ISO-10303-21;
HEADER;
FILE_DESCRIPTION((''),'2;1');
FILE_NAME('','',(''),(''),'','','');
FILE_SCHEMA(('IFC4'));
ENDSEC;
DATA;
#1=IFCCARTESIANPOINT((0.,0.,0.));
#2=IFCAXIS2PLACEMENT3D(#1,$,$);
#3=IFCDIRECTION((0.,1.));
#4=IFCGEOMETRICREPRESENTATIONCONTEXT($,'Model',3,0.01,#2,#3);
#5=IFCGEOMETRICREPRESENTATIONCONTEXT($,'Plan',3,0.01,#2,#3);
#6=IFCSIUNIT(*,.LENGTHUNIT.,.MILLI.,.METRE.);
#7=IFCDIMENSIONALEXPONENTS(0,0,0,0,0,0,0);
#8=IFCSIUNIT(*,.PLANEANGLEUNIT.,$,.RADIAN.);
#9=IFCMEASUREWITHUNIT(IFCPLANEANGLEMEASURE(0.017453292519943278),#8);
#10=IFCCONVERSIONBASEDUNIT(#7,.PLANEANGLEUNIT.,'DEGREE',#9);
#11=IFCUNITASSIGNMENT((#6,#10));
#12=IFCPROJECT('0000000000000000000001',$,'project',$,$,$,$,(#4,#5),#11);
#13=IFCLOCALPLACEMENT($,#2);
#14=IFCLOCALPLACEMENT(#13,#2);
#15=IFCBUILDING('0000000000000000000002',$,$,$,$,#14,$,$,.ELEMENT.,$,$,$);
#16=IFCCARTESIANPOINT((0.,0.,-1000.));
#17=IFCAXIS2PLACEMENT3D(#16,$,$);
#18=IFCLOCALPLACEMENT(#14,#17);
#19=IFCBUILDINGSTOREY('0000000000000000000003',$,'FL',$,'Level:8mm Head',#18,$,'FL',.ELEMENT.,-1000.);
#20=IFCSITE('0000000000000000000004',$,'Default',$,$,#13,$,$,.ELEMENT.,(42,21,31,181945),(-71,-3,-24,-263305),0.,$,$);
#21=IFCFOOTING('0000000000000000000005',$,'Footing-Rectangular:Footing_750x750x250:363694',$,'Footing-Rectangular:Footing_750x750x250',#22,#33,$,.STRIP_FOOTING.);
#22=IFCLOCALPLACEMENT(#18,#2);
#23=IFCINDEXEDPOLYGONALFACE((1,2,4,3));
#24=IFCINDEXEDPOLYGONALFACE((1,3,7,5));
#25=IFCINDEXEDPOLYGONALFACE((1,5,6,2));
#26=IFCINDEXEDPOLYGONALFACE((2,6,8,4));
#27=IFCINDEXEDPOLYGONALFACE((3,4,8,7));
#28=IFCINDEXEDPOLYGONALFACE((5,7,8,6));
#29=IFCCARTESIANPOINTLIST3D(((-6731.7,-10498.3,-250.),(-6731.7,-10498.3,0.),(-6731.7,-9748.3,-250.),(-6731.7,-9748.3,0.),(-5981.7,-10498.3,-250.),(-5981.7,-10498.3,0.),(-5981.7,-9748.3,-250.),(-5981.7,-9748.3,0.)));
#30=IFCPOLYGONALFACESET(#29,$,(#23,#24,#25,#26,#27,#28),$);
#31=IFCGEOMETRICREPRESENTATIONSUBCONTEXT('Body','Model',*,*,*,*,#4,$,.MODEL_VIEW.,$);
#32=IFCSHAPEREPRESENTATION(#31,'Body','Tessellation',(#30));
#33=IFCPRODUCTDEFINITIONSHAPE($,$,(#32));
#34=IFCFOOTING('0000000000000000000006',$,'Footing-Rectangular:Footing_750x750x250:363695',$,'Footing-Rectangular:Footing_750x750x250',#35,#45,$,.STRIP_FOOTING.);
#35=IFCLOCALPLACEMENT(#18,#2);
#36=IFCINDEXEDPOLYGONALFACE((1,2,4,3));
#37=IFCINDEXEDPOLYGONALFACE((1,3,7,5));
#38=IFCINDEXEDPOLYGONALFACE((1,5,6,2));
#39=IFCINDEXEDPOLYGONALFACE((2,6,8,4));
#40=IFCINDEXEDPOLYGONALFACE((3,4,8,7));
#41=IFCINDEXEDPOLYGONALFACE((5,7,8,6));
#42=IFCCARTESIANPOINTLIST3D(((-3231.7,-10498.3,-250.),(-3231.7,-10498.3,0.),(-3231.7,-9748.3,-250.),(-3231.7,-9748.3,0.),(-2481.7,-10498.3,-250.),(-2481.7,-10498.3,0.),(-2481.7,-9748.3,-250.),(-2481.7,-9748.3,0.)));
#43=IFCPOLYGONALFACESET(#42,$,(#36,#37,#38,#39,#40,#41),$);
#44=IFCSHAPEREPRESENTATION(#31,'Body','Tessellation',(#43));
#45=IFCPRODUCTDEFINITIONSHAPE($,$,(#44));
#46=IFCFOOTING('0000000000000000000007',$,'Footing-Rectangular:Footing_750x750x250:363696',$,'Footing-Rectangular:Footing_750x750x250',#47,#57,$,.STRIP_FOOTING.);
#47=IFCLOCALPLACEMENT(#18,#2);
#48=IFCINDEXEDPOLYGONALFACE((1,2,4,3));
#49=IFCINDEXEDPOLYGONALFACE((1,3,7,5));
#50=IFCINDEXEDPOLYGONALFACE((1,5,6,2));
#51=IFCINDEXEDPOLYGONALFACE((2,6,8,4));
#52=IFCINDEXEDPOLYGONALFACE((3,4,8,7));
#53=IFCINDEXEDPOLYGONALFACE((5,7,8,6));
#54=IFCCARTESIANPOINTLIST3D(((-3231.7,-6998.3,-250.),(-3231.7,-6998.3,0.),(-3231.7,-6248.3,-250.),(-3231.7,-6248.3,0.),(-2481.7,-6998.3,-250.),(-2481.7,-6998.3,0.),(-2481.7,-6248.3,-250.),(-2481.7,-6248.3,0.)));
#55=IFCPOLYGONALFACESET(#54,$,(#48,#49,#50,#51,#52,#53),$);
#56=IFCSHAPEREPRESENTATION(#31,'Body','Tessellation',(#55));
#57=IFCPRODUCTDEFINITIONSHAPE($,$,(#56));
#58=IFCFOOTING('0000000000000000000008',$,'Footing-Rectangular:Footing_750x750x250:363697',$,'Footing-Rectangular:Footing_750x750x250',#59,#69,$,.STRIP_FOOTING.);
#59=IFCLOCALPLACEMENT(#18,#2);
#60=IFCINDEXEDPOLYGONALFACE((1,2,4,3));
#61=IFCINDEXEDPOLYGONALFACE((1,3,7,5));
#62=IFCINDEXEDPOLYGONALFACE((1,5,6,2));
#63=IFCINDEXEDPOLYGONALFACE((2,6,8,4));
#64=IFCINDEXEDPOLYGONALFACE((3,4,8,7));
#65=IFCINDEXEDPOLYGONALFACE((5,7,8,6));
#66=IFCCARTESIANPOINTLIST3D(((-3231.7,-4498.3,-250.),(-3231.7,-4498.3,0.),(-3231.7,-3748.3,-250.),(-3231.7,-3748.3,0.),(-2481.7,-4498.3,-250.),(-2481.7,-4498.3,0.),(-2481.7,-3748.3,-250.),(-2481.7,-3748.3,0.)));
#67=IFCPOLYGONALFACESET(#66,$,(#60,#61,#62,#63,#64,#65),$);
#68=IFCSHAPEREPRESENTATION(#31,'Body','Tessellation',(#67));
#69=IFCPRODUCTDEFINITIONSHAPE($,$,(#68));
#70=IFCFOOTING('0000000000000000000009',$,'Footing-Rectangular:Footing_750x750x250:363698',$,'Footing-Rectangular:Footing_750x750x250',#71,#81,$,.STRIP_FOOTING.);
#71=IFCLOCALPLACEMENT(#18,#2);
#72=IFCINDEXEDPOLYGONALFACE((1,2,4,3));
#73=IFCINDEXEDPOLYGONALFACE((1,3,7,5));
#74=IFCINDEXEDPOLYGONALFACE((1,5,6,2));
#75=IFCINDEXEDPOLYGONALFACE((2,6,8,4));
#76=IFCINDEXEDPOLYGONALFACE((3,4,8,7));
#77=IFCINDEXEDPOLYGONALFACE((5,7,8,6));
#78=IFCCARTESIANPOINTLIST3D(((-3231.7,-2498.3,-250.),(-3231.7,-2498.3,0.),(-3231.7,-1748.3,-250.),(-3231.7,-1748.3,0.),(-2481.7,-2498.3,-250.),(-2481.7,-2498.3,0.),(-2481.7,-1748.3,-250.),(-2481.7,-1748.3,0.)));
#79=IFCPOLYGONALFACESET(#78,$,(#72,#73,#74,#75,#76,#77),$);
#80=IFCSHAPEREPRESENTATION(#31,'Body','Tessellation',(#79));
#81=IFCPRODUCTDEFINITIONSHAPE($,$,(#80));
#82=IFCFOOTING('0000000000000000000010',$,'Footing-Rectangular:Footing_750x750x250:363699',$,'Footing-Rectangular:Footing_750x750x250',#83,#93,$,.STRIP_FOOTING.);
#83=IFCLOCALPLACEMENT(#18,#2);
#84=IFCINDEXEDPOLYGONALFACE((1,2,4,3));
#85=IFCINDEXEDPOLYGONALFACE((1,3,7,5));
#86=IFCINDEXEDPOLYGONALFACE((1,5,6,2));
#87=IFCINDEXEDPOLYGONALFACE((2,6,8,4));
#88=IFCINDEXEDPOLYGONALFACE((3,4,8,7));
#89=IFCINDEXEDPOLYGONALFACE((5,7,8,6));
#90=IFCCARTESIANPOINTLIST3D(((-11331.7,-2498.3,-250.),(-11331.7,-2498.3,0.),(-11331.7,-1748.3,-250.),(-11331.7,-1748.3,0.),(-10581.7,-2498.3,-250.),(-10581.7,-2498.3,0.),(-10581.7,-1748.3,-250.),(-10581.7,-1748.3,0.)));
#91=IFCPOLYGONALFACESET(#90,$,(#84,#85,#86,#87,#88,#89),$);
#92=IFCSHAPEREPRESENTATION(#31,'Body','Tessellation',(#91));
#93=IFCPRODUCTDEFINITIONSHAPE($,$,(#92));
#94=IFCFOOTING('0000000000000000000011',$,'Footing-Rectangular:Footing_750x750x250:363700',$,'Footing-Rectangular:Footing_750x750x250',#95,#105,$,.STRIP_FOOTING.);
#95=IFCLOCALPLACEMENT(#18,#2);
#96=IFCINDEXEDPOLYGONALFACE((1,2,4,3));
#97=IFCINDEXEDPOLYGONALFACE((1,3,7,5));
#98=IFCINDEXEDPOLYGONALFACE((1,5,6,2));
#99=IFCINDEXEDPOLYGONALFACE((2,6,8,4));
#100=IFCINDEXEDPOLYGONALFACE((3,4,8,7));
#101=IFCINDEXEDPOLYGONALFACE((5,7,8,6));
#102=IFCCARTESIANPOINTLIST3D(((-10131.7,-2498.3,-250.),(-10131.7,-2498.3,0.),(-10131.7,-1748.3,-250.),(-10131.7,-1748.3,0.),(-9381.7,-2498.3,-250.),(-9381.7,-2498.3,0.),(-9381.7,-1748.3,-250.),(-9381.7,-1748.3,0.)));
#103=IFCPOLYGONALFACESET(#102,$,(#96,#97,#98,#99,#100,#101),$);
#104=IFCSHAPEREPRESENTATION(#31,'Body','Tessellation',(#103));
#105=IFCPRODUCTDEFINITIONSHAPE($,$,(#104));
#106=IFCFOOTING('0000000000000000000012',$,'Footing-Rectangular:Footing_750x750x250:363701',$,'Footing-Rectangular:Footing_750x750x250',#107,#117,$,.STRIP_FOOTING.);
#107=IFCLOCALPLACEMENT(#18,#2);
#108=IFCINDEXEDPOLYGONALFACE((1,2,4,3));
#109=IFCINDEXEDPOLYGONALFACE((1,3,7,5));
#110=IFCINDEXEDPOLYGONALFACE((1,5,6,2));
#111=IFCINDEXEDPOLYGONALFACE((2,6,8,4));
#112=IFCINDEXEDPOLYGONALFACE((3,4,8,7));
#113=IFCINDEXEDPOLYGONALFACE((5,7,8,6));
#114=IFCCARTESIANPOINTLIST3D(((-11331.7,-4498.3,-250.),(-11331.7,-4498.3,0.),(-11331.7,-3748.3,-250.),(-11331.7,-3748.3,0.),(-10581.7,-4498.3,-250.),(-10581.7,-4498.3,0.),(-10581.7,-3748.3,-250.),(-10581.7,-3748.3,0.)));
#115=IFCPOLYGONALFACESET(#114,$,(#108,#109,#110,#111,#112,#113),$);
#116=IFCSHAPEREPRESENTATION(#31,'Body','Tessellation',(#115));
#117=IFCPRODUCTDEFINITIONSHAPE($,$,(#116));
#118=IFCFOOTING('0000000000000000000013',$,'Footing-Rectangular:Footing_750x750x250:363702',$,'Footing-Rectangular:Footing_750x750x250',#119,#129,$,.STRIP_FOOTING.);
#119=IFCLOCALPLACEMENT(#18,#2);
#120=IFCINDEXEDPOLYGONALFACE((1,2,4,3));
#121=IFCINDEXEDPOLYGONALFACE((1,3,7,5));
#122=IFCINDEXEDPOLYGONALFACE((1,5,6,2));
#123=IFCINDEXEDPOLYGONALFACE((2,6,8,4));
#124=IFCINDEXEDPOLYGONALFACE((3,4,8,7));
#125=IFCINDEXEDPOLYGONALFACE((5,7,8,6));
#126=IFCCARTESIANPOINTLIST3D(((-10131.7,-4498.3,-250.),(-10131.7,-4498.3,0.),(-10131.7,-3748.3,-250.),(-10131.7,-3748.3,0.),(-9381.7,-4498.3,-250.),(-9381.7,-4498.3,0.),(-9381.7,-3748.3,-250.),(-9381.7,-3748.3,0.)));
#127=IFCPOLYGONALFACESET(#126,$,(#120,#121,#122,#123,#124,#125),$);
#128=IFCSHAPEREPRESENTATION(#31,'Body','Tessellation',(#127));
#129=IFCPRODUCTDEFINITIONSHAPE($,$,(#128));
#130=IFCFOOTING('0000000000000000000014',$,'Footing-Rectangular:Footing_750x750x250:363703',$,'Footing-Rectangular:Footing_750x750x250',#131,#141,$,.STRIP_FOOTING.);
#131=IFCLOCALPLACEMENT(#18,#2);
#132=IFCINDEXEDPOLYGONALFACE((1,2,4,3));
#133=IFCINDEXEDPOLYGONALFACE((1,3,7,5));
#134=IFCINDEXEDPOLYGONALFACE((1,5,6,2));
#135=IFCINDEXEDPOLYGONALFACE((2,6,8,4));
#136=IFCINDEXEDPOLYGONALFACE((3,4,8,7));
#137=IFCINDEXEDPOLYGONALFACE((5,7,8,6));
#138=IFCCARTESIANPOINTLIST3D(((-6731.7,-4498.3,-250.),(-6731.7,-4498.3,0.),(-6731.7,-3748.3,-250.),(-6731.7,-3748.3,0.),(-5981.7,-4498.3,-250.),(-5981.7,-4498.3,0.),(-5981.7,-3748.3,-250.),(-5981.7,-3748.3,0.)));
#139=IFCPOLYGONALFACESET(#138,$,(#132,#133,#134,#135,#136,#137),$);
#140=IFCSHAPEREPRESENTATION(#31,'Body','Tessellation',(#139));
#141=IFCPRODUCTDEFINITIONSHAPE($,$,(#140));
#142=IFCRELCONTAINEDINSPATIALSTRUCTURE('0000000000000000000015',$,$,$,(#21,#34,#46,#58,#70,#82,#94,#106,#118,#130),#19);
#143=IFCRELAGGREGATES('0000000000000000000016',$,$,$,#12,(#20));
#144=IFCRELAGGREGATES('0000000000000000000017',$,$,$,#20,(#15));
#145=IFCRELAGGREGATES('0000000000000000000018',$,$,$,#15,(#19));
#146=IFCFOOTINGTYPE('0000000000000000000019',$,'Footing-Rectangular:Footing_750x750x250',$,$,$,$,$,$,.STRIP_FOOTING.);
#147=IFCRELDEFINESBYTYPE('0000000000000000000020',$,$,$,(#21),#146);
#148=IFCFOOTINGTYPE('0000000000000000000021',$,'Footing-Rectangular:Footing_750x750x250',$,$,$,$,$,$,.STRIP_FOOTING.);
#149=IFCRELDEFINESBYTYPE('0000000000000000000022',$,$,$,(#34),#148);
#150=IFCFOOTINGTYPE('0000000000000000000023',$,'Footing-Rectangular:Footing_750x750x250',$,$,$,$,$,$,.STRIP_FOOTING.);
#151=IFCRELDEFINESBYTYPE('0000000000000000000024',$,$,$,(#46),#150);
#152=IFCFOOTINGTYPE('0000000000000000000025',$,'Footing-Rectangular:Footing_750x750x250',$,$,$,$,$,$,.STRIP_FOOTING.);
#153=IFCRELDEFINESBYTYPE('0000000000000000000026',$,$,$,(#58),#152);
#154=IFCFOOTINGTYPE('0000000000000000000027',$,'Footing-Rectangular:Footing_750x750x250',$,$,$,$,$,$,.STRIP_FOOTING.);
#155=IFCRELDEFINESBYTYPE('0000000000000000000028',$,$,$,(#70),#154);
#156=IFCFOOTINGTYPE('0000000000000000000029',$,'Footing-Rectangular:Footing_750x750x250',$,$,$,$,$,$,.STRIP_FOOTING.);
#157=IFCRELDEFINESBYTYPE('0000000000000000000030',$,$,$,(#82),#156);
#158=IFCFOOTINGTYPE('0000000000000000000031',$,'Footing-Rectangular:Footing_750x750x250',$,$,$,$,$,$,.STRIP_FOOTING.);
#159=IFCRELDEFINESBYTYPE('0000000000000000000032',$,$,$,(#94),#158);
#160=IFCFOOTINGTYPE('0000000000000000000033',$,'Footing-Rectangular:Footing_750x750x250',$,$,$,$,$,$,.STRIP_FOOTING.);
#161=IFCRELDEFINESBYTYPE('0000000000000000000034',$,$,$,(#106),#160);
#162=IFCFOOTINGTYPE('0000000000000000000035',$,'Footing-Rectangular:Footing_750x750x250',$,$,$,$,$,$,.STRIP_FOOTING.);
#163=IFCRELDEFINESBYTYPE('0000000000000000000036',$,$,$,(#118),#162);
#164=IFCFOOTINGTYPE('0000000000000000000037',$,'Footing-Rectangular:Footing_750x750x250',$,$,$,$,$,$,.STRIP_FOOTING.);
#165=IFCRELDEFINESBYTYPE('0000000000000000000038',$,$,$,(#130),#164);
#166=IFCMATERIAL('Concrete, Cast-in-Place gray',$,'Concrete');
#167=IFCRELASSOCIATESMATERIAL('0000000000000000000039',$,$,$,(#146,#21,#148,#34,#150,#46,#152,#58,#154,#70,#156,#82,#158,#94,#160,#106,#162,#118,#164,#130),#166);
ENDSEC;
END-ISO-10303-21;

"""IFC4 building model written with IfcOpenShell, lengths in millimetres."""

from ifc_helpers import new_model, entity, si_unit, converted_unit, direction, frame, origin, place, context, subcontext, project, spatial, indexed_curve, outline, extrude, source, transform, mapped, material, type_object, type_shapes, element, save


model = new_model("IFC4")

# Units and contexts
model_context = context("Model", 3, precision=0.01, world=origin(), true_north=direction((0.0, 1.0)))
plan_context = context("Plan", 3, precision=0.01, world=origin(), true_north=direction((0.0, 1.0)))
body_context = subcontext(model_context, "Body", "Model", "MODEL_VIEW")
ifc_project = project(units=[si_unit("LENGTHUNIT", "METRE", prefix="MILLI"), converted_unit("PLANEANGLEUNIT", "DEGREE", entity("IfcPlaneAngleMeasure", 0.017453292519943278), si_unit("PLANEANGLEUNIT", "RADIAN"), dimensions=[0, 0, 0, 0, 0, 0, 0])], contexts=[model_context, plan_context])

# Site, building, storey
site_placement = place(None, origin())
site = spatial("IfcSite", under=ifc_project, at=site_placement, Name="Default", CompositionType="ELEMENT", RefLatitude=(42, 21, 31, 181945), RefLongitude=(-71, -3, -24, -263305), RefElevation=0.0)
building_placement = place(site_placement, origin())
building = spatial("IfcBuilding", under=site, at=building_placement, CompositionType="ELEMENT")
storey_placement = place(building_placement, frame((0.0, 0.0, -1000.0)))
storey = spatial("IfcBuildingStorey", under=building, at=storey_placement, Name="FL", ObjectType="Level:8mm Head", LongName="FL", CompositionType="ELEMENT", Elevation=-1000.0)

# Footings
ifc_material = material(Name="Concrete, Cast-in-Place gray", Category="Concrete")
footing_type_1 = type_object("IfcFootingType", Name="Footing-Rectangular:Footing_750x750x250", PredefinedType="STRIP_FOOTING", material=ifc_material)
shared_shape_1 = source(origin(), body_context, "Body", "SweptSolid", [
    extrude(outline(indexed_curve([(-375.0, -375.0), (375.0, -375.0), (375.0, 375.0), (-375.0, 375.0), (-375.0, -375.0)], self_intersect=False)), frame((-6356.7, -10123.3, -1250.0)), (0.0, 0.0, 1.0), 250.0),
])
type_shapes(footing_type_1, [shared_shape_1])
footing_1_placement = place(storey_placement, frame((0.0, 0.0, 1000.0)))
element("IfcFooting", 1, at=footing_1_placement, inside=storey, type_object=footing_type_1, material=ifc_material, Name="Footing-Rectangular:Footing_750x750x250:363694", ObjectType="Footing-Rectangular:Footing_750x750x250", PredefinedType="STRIP_FOOTING", context=body_context, shape_type="MappedRepresentation", body=[
    mapped(shared_shape_1, transform((0.0, 0.0, 0.0), scale=1.0)),
])
footing_type_2 = type_object("IfcFootingType", Name="Footing-Rectangular:Footing_750x750x250", PredefinedType="STRIP_FOOTING", material=ifc_material)
shared_shape_2 = source(origin(), body_context, "Body", "SweptSolid", [
    extrude(outline(indexed_curve([(-375.0, -375.0), (375.0, -375.0), (375.0, 375.0), (-375.0, 375.0), (-375.0, -375.0)], self_intersect=False)), frame((-2856.7, -10123.3, -1250.0), z_axis=(0.0, 0.0, 1.0), x_axis=(0.0, 1.0, 0.0)), (0.0, 0.0, 1.0), 250.0),
])
type_shapes(footing_type_2, [shared_shape_2])
footing_2_placement = place(storey_placement, frame((0.0, 0.0, 1000.0)))
element("IfcFooting", 2, at=footing_2_placement, inside=storey, type_object=footing_type_2, material=ifc_material, Name="Footing-Rectangular:Footing_750x750x250:363695", ObjectType="Footing-Rectangular:Footing_750x750x250", PredefinedType="STRIP_FOOTING", context=body_context, shape_type="MappedRepresentation", body=[
    mapped(shared_shape_2, transform((0.0, 0.0, 0.0), scale=1.0)),
])
footing_type_3 = type_object("IfcFootingType", Name="Footing-Rectangular:Footing_750x750x250", PredefinedType="STRIP_FOOTING", material=ifc_material)
shared_shape_3 = source(origin(), body_context, "Body", "SweptSolid", [
    extrude(outline(indexed_curve([(-375.0, -375.0), (375.0, -375.0), (375.0, 375.0), (-375.0, 375.0), (-375.0, -375.0)], self_intersect=False)), frame((-2856.7, -6623.3, -1250.0), z_axis=(0.0, 0.0, 1.0), x_axis=(-1.0, 0.0, 0.0)), (0.0, 0.0, 1.0), 250.0),
])
type_shapes(footing_type_3, [shared_shape_3])
footing_3_placement = place(storey_placement, frame((0.0, 0.0, 1000.0)))
element("IfcFooting", 3, at=footing_3_placement, inside=storey, type_object=footing_type_3, material=ifc_material, Name="Footing-Rectangular:Footing_750x750x250:363696", ObjectType="Footing-Rectangular:Footing_750x750x250", PredefinedType="STRIP_FOOTING", context=body_context, shape_type="MappedRepresentation", body=[
    mapped(shared_shape_3, transform((0.0, 0.0, 0.0), scale=1.0)),
])
footing_type_4 = type_object("IfcFootingType", Name="Footing-Rectangular:Footing_750x750x250", PredefinedType="STRIP_FOOTING", material=ifc_material)
shared_shape_4 = source(origin(), body_context, "Body", "SweptSolid", [
    extrude(outline(indexed_curve([(-375.0, -375.0), (375.0, -375.0), (375.0, 375.0), (-375.0, 375.0), (-375.0, -375.0)], self_intersect=False)), frame((-2856.7, -4123.3, -1250.0), z_axis=(0.0, 0.0, 1.0), x_axis=(0.0, -1.0, 0.0)), (0.0, 0.0, 1.0), 250.0),
])
type_shapes(footing_type_4, [shared_shape_4])
footing_4_placement = place(storey_placement, frame((0.0, 0.0, 1000.0)))
element("IfcFooting", 4, at=footing_4_placement, inside=storey, type_object=footing_type_4, material=ifc_material, Name="Footing-Rectangular:Footing_750x750x250:363697", ObjectType="Footing-Rectangular:Footing_750x750x250", PredefinedType="STRIP_FOOTING", context=body_context, shape_type="MappedRepresentation", body=[
    mapped(shared_shape_4, transform((0.0, 0.0, 0.0), scale=1.0)),
])
footing_type_5 = type_object("IfcFootingType", Name="Footing-Rectangular:Footing_750x750x250", PredefinedType="STRIP_FOOTING", material=ifc_material)
shared_shape_5 = source(origin(), body_context, "Body", "SweptSolid", [
    extrude(outline(indexed_curve([(-375.0, -375.0), (375.0, -375.0), (375.0, 375.0), (-375.0, 375.0), (-375.0, -375.0)], self_intersect=False)), frame((-2856.7, -2123.3, -1250.0)), (0.0, 0.0, 1.0), 250.0),
])
type_shapes(footing_type_5, [shared_shape_5])
footing_5_placement = place(storey_placement, frame((0.0, 0.0, 1000.0)))
element("IfcFooting", 5, at=footing_5_placement, inside=storey, type_object=footing_type_5, material=ifc_material, Name="Footing-Rectangular:Footing_750x750x250:363698", ObjectType="Footing-Rectangular:Footing_750x750x250", PredefinedType="STRIP_FOOTING", context=body_context, shape_type="MappedRepresentation", body=[
    mapped(shared_shape_5, transform((0.0, 0.0, 0.0), scale=1.0)),
])
footing_type_6 = type_object("IfcFootingType", Name="Footing-Rectangular:Footing_750x750x250", PredefinedType="STRIP_FOOTING", material=ifc_material)
shared_shape_6 = source(origin(), body_context, "Body", "SweptSolid", [
    extrude(outline(indexed_curve([(-375.0, -375.0), (375.0, -375.0), (375.0, 375.0), (-375.0, 375.0), (-375.0, -375.0)], self_intersect=False)), frame((-10956.7, -2123.3, -1250.0), z_axis=(0.0, 0.0, 1.0), x_axis=(0.0, -1.0, 0.0)), (0.0, 0.0, 1.0), 250.0),
])
type_shapes(footing_type_6, [shared_shape_6])
footing_6_placement = place(storey_placement, frame((0.0, 0.0, 1000.0)))
element("IfcFooting", 6, at=footing_6_placement, inside=storey, type_object=footing_type_6, material=ifc_material, Name="Footing-Rectangular:Footing_750x750x250:363699", ObjectType="Footing-Rectangular:Footing_750x750x250", PredefinedType="STRIP_FOOTING", context=body_context, shape_type="MappedRepresentation", body=[
    mapped(shared_shape_6, transform((0.0, 0.0, 0.0), scale=1.0)),
])
footing_type_7 = type_object("IfcFootingType", Name="Footing-Rectangular:Footing_750x750x250", PredefinedType="STRIP_FOOTING", material=ifc_material)
shared_shape_7 = source(origin(), body_context, "Body", "SweptSolid", [
    extrude(outline(indexed_curve([(-375.0, -375.0), (375.0, -375.0), (375.0, 375.0), (-375.0, 375.0), (-375.0, -375.0)], self_intersect=False)), frame((-9756.7, -2123.3, -1250.0)), (0.0, 0.0, 1.0), 250.0),
])
type_shapes(footing_type_7, [shared_shape_7])
footing_7_placement = place(storey_placement, frame((0.0, 0.0, 1000.0)))
element("IfcFooting", 7, at=footing_7_placement, inside=storey, type_object=footing_type_7, material=ifc_material, Name="Footing-Rectangular:Footing_750x750x250:363700", ObjectType="Footing-Rectangular:Footing_750x750x250", PredefinedType="STRIP_FOOTING", context=body_context, shape_type="MappedRepresentation", body=[
    mapped(shared_shape_7, transform((0.0, 0.0, 0.0), scale=1.0)),
])
footing_type_8 = type_object("IfcFootingType", Name="Footing-Rectangular:Footing_750x750x250", PredefinedType="STRIP_FOOTING", material=ifc_material)
shared_shape_8 = source(origin(), body_context, "Body", "SweptSolid", [
    extrude(outline(indexed_curve([(-375.0, -375.0), (375.0, -375.0), (375.0, 375.0), (-375.0, 375.0), (-375.0, -375.0)], self_intersect=False)), frame((-10956.7, -4123.3, -1250.0), z_axis=(0.0, 0.0, 1.0), x_axis=(0.0, 1.0, 0.0)), (0.0, 0.0, 1.0), 250.0),
])
type_shapes(footing_type_8, [shared_shape_8])
footing_8_placement = place(storey_placement, frame((0.0, 0.0, 1000.0)))
element("IfcFooting", 8, at=footing_8_placement, inside=storey, type_object=footing_type_8, material=ifc_material, Name="Footing-Rectangular:Footing_750x750x250:363701", ObjectType="Footing-Rectangular:Footing_750x750x250", PredefinedType="STRIP_FOOTING", context=body_context, shape_type="MappedRepresentation", body=[
    mapped(shared_shape_8, transform((0.0, 0.0, 0.0), scale=1.0)),
])
footing_type_9 = type_object("IfcFootingType", Name="Footing-Rectangular:Footing_750x750x250", PredefinedType="STRIP_FOOTING", material=ifc_material)
shared_shape_9 = source(origin(), body_context, "Body", "SweptSolid", [
    extrude(outline(indexed_curve([(-375.0, -375.0), (375.0, -375.0), (375.0, 375.0), (-375.0, 375.0), (-375.0, -375.0)], self_intersect=False)), frame((-9756.7, -4123.3, -1250.0), z_axis=(0.0, 0.0, 1.0), x_axis=(0.0, 1.0, 0.0)), (0.0, 0.0, 1.0), 250.0),
])
type_shapes(footing_type_9, [shared_shape_9])
footing_9_placement = place(storey_placement, frame((0.0, 0.0, 1000.0)))
element("IfcFooting", 9, at=footing_9_placement, inside=storey, type_object=footing_type_9, material=ifc_material, Name="Footing-Rectangular:Footing_750x750x250:363702", ObjectType="Footing-Rectangular:Footing_750x750x250", PredefinedType="STRIP_FOOTING", context=body_context, shape_type="MappedRepresentation", body=[
    mapped(shared_shape_9, transform((0.0, 0.0, 0.0), scale=1.0)),
])
footing_type_10 = type_object("IfcFootingType", Name="Footing-Rectangular:Footing_750x750x250", PredefinedType="STRIP_FOOTING", material=ifc_material)
shared_shape_10 = source(origin(), body_context, "Body", "SweptSolid", [
    extrude(outline(indexed_curve([(-375.0, -375.0), (375.0, -375.0), (375.0, 375.0), (-375.0, 375.0), (-375.0, -375.0)], self_intersect=False)), frame((-6356.7, -4123.3, -1250.0), z_axis=(0.0, 0.0, 1.0), x_axis=(0.0, 1.0, 0.0)), (0.0, 0.0, 1.0), 250.0),
])
type_shapes(footing_type_10, [shared_shape_10])
footing_10_placement = place(storey_placement, frame((0.0, 0.0, 1000.0)))
element("IfcFooting", 10, at=footing_10_placement, inside=storey, type_object=footing_type_10, material=ifc_material, Name="Footing-Rectangular:Footing_750x750x250:363703", ObjectType="Footing-Rectangular:Footing_750x750x250", PredefinedType="STRIP_FOOTING", context=body_context, shape_type="MappedRepresentation", body=[
    mapped(shared_shape_10, transform((0.0, 0.0, 0.0), scale=1.0)),
])

save(model, "model.ifc")
